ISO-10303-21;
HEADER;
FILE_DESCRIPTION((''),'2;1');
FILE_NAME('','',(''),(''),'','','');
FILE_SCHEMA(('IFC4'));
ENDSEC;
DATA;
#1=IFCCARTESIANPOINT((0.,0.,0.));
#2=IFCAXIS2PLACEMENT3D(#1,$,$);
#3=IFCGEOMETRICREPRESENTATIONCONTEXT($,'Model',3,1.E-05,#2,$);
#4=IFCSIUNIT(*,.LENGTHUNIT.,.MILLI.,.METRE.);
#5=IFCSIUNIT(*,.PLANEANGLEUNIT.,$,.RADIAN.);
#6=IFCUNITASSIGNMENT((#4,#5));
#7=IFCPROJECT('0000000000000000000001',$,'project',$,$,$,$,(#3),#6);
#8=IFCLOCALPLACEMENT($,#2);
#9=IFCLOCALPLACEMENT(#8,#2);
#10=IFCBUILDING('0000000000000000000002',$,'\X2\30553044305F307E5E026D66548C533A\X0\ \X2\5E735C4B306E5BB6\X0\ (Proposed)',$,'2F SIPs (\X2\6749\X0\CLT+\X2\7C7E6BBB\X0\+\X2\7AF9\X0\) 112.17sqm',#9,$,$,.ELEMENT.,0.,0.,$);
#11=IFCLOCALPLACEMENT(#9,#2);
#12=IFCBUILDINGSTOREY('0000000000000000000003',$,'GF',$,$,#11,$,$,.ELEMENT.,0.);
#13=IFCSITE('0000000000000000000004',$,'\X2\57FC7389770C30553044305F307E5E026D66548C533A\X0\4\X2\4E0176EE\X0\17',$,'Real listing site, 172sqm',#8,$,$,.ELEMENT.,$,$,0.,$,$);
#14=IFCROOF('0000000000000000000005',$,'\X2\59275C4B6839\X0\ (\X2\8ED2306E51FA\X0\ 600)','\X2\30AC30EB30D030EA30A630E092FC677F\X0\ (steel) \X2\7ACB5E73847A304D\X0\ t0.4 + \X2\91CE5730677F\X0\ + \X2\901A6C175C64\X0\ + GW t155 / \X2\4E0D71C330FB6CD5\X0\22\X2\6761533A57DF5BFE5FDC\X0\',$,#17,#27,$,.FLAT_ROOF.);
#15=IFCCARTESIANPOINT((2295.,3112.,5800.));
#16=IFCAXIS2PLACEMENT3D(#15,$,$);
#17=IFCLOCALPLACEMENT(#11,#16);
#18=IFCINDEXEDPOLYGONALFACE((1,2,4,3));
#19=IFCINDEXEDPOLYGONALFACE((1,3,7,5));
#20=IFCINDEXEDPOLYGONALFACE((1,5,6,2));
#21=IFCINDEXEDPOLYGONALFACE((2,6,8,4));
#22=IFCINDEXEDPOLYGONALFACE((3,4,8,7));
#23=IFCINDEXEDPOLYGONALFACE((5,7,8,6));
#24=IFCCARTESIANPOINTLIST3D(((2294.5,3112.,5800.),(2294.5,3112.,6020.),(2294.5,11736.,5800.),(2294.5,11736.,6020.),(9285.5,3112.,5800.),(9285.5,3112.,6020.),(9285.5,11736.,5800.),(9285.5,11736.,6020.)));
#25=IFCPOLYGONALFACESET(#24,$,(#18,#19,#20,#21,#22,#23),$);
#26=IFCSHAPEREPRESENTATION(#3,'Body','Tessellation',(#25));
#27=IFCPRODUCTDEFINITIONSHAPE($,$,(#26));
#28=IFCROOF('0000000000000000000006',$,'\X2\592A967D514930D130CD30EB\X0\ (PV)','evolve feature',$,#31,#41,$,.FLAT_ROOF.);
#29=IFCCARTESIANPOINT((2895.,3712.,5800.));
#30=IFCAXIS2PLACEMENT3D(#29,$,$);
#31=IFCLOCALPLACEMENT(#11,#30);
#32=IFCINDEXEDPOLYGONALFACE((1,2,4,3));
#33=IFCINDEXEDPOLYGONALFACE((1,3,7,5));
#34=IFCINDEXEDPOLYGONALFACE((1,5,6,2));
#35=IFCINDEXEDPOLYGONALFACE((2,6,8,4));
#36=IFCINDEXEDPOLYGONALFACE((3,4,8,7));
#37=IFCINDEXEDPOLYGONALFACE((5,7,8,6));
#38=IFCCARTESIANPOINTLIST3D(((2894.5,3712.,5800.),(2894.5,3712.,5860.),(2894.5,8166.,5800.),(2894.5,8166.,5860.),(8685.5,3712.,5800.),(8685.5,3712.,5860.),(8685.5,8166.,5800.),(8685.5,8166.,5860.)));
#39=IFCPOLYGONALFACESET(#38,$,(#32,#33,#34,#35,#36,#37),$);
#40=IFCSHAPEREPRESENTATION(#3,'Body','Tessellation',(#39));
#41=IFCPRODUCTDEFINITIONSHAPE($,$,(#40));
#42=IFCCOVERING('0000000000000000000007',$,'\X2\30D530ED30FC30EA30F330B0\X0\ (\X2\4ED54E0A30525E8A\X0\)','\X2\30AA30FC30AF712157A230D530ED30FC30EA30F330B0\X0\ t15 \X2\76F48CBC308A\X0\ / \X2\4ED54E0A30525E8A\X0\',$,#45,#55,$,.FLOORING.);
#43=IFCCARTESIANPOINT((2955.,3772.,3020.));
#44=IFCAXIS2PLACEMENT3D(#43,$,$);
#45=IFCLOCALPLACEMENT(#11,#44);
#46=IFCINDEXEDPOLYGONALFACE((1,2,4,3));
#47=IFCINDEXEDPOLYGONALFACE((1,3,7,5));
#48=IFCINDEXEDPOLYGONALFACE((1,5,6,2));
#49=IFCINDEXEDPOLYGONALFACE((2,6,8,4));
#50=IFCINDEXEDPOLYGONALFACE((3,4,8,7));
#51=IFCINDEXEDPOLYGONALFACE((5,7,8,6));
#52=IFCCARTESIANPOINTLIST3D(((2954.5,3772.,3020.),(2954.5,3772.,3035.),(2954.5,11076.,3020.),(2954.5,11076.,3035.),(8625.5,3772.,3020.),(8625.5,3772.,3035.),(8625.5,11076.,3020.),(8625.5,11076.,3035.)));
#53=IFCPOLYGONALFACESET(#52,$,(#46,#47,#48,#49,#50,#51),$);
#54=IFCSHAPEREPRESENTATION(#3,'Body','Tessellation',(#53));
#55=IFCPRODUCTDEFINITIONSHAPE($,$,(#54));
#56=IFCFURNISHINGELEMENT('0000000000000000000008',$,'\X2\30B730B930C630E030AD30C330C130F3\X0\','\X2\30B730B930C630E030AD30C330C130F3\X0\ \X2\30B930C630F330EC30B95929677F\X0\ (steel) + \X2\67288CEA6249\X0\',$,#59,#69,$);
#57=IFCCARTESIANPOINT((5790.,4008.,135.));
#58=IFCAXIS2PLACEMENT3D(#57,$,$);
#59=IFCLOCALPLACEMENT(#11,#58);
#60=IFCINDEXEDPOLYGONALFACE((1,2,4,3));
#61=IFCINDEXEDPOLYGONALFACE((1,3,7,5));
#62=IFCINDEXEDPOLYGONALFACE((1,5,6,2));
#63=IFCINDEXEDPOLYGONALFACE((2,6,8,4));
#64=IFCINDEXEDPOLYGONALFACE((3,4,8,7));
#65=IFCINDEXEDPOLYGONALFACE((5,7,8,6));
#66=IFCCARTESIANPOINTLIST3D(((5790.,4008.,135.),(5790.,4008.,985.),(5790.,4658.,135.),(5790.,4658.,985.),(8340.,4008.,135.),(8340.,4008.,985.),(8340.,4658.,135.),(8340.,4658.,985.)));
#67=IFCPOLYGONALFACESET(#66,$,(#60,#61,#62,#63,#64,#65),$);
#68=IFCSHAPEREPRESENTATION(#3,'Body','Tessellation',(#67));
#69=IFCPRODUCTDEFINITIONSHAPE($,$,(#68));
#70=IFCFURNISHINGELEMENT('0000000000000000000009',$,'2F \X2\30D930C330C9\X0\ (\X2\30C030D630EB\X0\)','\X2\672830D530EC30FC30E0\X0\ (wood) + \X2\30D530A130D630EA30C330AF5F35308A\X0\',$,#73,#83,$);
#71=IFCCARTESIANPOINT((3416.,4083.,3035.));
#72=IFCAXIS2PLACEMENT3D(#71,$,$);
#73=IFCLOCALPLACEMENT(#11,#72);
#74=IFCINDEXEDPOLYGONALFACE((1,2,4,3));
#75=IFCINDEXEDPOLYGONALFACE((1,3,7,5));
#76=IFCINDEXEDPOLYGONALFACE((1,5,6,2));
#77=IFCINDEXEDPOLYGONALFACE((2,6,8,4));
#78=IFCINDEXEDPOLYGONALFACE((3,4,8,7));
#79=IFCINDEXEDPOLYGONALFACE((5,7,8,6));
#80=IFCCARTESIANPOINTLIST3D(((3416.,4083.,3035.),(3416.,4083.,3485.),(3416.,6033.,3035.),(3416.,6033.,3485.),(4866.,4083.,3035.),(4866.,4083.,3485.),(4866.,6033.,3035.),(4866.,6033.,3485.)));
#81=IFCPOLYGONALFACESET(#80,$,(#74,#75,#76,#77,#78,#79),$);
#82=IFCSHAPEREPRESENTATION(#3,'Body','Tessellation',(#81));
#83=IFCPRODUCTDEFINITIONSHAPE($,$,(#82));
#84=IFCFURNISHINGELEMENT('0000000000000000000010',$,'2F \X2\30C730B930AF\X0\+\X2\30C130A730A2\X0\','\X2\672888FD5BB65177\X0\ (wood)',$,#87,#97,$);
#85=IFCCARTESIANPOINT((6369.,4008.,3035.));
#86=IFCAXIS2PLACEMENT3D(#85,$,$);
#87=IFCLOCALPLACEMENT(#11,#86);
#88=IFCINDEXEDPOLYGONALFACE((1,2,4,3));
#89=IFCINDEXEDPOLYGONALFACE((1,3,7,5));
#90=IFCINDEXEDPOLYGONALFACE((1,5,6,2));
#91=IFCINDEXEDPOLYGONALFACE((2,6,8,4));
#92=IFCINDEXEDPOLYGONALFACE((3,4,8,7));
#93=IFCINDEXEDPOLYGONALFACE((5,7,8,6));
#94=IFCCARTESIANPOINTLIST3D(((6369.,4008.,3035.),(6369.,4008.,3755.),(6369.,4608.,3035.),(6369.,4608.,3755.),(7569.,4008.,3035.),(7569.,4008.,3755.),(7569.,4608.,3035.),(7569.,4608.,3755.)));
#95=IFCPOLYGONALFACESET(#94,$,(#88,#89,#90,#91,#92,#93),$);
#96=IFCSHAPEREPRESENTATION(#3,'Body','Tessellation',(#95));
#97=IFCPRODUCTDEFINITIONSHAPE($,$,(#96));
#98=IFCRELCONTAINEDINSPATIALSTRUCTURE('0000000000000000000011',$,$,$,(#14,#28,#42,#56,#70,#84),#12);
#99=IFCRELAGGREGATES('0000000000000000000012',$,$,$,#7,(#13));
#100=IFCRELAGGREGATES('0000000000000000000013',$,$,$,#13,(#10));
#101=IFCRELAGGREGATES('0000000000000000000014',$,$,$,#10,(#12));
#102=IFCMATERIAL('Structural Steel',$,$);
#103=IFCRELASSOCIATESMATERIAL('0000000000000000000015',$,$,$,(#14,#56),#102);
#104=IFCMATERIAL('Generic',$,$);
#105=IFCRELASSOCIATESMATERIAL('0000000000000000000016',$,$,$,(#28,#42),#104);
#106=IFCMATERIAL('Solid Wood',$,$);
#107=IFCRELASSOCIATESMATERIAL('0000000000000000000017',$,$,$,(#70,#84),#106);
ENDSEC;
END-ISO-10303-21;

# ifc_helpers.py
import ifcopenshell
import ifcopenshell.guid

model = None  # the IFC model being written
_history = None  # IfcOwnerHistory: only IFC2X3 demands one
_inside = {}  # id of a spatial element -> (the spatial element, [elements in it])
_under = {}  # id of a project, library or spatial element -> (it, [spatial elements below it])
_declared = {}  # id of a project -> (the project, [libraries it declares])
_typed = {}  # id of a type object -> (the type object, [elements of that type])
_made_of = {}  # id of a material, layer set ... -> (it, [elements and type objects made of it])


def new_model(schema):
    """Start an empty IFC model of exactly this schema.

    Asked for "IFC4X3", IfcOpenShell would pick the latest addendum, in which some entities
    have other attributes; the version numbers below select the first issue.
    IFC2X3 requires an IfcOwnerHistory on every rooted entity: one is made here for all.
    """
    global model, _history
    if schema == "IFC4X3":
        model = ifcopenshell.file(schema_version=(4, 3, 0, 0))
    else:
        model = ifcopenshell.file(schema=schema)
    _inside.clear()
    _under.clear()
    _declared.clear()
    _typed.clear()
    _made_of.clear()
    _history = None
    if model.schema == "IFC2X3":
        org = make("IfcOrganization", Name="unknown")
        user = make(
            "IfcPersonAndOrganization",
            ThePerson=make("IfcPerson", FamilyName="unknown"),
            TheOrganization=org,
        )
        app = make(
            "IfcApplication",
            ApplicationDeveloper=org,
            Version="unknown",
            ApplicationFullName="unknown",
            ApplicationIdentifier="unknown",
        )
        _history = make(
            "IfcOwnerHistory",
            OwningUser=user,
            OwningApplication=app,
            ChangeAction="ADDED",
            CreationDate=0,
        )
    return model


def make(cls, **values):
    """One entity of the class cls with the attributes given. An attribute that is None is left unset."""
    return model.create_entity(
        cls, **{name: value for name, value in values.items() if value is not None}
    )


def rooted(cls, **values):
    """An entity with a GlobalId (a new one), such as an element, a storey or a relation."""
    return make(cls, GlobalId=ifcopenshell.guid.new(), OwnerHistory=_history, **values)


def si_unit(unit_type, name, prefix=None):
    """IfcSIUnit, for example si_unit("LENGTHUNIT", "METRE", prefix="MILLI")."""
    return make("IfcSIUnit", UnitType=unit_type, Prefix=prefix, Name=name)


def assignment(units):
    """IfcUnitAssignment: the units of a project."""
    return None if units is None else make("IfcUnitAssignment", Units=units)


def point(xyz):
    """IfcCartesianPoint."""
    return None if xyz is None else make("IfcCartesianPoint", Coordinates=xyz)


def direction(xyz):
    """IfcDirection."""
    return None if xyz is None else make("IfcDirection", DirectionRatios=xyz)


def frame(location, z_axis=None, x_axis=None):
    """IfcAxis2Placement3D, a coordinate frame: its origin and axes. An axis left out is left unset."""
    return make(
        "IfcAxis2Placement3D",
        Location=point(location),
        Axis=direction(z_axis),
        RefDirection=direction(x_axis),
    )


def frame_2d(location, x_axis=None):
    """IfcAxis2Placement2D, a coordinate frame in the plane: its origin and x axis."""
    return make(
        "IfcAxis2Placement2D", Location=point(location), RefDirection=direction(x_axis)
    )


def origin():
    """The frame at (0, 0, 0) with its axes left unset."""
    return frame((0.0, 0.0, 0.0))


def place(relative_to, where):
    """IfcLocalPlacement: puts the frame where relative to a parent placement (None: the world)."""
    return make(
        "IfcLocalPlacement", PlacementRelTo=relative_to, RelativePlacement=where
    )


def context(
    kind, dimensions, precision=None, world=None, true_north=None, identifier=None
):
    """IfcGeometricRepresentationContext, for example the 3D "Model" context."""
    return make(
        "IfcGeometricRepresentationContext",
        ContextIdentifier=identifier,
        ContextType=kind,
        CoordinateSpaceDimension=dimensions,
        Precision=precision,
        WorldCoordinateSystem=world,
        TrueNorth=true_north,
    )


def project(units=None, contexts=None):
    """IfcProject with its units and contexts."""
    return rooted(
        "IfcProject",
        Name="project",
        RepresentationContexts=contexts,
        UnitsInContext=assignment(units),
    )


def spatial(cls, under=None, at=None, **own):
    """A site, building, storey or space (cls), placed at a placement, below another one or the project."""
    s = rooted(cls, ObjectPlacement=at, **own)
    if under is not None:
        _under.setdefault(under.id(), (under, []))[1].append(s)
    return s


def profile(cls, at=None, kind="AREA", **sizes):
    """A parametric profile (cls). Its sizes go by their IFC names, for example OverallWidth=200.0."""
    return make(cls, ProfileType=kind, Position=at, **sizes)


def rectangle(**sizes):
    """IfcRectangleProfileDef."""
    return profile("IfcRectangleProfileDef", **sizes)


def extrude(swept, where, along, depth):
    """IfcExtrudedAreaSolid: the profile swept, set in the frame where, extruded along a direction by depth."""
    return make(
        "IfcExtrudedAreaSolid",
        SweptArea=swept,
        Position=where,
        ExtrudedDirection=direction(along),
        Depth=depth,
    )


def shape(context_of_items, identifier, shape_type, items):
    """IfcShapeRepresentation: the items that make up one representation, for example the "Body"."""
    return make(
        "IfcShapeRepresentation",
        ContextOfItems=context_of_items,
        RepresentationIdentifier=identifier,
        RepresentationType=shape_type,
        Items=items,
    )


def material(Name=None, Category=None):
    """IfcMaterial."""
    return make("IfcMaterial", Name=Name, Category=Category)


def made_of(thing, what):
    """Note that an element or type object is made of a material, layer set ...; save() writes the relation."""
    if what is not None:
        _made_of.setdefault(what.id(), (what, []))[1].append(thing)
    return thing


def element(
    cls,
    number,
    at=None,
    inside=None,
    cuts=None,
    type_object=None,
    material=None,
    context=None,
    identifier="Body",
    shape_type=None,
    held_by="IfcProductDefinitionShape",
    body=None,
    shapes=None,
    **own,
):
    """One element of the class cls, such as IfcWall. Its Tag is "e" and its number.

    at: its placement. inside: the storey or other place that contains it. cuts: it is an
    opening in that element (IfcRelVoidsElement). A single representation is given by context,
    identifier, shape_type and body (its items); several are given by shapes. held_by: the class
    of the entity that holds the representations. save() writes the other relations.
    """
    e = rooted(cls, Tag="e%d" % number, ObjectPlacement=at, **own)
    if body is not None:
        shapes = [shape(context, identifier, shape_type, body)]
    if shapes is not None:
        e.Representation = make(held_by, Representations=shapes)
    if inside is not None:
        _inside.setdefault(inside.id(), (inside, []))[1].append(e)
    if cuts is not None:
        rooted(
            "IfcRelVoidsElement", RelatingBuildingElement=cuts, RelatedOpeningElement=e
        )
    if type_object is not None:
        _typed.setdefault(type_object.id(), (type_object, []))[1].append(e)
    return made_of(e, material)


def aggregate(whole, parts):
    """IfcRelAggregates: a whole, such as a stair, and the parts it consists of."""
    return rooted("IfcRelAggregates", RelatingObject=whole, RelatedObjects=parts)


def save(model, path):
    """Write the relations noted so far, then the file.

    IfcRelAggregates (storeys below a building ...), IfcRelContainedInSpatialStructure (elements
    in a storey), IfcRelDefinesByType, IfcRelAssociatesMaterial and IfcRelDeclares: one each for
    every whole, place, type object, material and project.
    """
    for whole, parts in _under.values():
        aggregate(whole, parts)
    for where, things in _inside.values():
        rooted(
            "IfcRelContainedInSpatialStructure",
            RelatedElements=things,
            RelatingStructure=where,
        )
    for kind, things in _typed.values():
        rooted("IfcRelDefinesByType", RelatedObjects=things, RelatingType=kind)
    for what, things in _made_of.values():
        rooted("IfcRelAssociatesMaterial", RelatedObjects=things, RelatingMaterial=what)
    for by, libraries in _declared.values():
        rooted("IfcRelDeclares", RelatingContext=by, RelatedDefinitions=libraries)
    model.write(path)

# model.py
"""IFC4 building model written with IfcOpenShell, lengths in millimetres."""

from ifc_helpers import new_model, si_unit, frame, frame_2d, origin, place, context, project, spatial, rectangle, extrude, material, element, save


model = new_model("IFC4")

# Units and contexts
model_context = context("Model", 3, precision=1e-05, world=origin())
ifc_project = project(units=[si_unit("LENGTHUNIT", "METRE", prefix="MILLI"), si_unit("PLANEANGLEUNIT", "RADIAN")], contexts=[model_context])

# Site, building, storey
site_placement = place(None, origin())
site = spatial("IfcSite", under=ifc_project, at=site_placement, Name="埼玉県さいたま市浦和区4丁目17", ObjectType="Real listing site, 172sqm", CompositionType="ELEMENT", RefElevation=0.0)
building_placement = place(site_placement, origin())
building = spatial("IfcBuilding", under=site, at=building_placement, Name="さいたま市浦和区 平屋の家 (Proposed)", ObjectType="2F SIPs (杉CLT+籾殻+竹) 112.17sqm", CompositionType="ELEMENT", ElevationOfRefHeight=0.0, ElevationOfTerrain=0.0)
storey_placement = place(building_placement, origin())
storey = spatial("IfcBuildingStorey", under=building, at=storey_placement, Name="GF", CompositionType="ELEMENT", Elevation=0.0)

# Shared definitions
ifc_material_1 = material(Name="Solid Wood")

# Shared definitions
ifc_material_2 = material(Name="Generic")

# Roofs
ifc_material_3 = material(Name="Structural Steel")
roof_1_placement = place(storey_placement, frame((2295.0, 3112.0, 5800.0)))
element("IfcRoof", 1, at=roof_1_placement, inside=storey, material=ifc_material_3, Name="大屋根 (軒の出 600)", Description="ガルバリウム鋼板 (steel) 立平葺き t0.4 + 野地板 + 通気層 + GW t155 / 不燃・法22条区域対応", PredefinedType="FLAT_ROOF", context=model_context, shape_type="SweptSolid", body=[
    extrude(rectangle(XDim=6991.0, YDim=8624.0, at=frame_2d((3495.0, 4312.0))), frame((2295.0, 3112.0, 5800.0)), (0.0, 0.0, 1.0), 220.0),
])
roof_2_placement = place(storey_placement, frame((2895.0, 3712.0, 5800.0)))
element("IfcRoof", 2, at=roof_2_placement, inside=storey, material=ifc_material_2, Name="太陽光パネル (PV)", Description="evolve feature", PredefinedType="FLAT_ROOF", context=model_context, shape_type="SweptSolid", body=[
    extrude(rectangle(XDim=5791.0, YDim=4454.0, at=frame_2d((2895.0, 2227.0))), frame((2895.0, 3712.0, 5800.0)), (0.0, 0.0, 1.0), 60.0),
])

# Covering
covering_placement = place(storey_placement, frame((2955.0, 3772.0, 3020.0)))
element("IfcCovering", 3, at=covering_placement, inside=storey, material=ifc_material_2, Name="フローリング (仕上げ床)", Description="オーク無垢フローリング t15 直貼り / 仕上げ床", PredefinedType="FLOORING", context=model_context, shape_type="SweptSolid", body=[
    extrude(rectangle(XDim=5671.0, YDim=7304.0, at=frame_2d((2835.0, 3652.0))), frame((2955.0, 3772.0, 3020.0)), (0.0, 0.0, 1.0), 15.0),
])

# Furnishing elements
furnishing_1_placement = place(storey_placement, frame((5790.0, 4008.0, 135.0)))
element("IfcFurnishingElement", 4, at=furnishing_1_placement, inside=storey, material=ifc_material_3, Name="システムキッチン", Description="システムキッチン ステンレス天板 (steel) + 木質扉", context=model_context, shape_type="SweptSolid", body=[
    extrude(rectangle(XDim=2550.0, YDim=650.0, at=frame_2d((1275.0, 325.0))), frame((5790.0, 4008.0, 135.0)), (0.0, 0.0, 1.0), 850.0),
])
furnishing_2_placement = place(storey_placement, frame((3416.0, 4083.0, 3035.0)))
element("IfcFurnishingElement", 5, at=furnishing_2_placement, inside=storey, material=ifc_material_1, Name="2F ベッド (ダブル)", Description="木フレーム (wood) + ファブリック張り", context=model_context, shape_type="SweptSolid", body=[
    extrude(rectangle(XDim=1450.0, YDim=1950.0, at=frame_2d((725.0, 975.0))), frame((3416.0, 4083.0, 3035.0)), (0.0, 0.0, 1.0), 450.0),
])
furnishing_3_placement = place(storey_placement, frame((6369.0, 4008.0, 3035.0)))
element("IfcFurnishingElement", 6, at=furnishing_3_placement, inside=storey, material=ifc_material_1, Name="2F デスク+チェア", Description="木製家具 (wood)", context=model_context, shape_type="SweptSolid", body=[
    extrude(rectangle(XDim=1200.0, YDim=600.0, at=frame_2d((600.0, 300.0))), frame((6369.0, 4008.0, 3035.0)), (0.0, 0.0, 1.0), 720.0),
])

save(model, "model.ifc")
